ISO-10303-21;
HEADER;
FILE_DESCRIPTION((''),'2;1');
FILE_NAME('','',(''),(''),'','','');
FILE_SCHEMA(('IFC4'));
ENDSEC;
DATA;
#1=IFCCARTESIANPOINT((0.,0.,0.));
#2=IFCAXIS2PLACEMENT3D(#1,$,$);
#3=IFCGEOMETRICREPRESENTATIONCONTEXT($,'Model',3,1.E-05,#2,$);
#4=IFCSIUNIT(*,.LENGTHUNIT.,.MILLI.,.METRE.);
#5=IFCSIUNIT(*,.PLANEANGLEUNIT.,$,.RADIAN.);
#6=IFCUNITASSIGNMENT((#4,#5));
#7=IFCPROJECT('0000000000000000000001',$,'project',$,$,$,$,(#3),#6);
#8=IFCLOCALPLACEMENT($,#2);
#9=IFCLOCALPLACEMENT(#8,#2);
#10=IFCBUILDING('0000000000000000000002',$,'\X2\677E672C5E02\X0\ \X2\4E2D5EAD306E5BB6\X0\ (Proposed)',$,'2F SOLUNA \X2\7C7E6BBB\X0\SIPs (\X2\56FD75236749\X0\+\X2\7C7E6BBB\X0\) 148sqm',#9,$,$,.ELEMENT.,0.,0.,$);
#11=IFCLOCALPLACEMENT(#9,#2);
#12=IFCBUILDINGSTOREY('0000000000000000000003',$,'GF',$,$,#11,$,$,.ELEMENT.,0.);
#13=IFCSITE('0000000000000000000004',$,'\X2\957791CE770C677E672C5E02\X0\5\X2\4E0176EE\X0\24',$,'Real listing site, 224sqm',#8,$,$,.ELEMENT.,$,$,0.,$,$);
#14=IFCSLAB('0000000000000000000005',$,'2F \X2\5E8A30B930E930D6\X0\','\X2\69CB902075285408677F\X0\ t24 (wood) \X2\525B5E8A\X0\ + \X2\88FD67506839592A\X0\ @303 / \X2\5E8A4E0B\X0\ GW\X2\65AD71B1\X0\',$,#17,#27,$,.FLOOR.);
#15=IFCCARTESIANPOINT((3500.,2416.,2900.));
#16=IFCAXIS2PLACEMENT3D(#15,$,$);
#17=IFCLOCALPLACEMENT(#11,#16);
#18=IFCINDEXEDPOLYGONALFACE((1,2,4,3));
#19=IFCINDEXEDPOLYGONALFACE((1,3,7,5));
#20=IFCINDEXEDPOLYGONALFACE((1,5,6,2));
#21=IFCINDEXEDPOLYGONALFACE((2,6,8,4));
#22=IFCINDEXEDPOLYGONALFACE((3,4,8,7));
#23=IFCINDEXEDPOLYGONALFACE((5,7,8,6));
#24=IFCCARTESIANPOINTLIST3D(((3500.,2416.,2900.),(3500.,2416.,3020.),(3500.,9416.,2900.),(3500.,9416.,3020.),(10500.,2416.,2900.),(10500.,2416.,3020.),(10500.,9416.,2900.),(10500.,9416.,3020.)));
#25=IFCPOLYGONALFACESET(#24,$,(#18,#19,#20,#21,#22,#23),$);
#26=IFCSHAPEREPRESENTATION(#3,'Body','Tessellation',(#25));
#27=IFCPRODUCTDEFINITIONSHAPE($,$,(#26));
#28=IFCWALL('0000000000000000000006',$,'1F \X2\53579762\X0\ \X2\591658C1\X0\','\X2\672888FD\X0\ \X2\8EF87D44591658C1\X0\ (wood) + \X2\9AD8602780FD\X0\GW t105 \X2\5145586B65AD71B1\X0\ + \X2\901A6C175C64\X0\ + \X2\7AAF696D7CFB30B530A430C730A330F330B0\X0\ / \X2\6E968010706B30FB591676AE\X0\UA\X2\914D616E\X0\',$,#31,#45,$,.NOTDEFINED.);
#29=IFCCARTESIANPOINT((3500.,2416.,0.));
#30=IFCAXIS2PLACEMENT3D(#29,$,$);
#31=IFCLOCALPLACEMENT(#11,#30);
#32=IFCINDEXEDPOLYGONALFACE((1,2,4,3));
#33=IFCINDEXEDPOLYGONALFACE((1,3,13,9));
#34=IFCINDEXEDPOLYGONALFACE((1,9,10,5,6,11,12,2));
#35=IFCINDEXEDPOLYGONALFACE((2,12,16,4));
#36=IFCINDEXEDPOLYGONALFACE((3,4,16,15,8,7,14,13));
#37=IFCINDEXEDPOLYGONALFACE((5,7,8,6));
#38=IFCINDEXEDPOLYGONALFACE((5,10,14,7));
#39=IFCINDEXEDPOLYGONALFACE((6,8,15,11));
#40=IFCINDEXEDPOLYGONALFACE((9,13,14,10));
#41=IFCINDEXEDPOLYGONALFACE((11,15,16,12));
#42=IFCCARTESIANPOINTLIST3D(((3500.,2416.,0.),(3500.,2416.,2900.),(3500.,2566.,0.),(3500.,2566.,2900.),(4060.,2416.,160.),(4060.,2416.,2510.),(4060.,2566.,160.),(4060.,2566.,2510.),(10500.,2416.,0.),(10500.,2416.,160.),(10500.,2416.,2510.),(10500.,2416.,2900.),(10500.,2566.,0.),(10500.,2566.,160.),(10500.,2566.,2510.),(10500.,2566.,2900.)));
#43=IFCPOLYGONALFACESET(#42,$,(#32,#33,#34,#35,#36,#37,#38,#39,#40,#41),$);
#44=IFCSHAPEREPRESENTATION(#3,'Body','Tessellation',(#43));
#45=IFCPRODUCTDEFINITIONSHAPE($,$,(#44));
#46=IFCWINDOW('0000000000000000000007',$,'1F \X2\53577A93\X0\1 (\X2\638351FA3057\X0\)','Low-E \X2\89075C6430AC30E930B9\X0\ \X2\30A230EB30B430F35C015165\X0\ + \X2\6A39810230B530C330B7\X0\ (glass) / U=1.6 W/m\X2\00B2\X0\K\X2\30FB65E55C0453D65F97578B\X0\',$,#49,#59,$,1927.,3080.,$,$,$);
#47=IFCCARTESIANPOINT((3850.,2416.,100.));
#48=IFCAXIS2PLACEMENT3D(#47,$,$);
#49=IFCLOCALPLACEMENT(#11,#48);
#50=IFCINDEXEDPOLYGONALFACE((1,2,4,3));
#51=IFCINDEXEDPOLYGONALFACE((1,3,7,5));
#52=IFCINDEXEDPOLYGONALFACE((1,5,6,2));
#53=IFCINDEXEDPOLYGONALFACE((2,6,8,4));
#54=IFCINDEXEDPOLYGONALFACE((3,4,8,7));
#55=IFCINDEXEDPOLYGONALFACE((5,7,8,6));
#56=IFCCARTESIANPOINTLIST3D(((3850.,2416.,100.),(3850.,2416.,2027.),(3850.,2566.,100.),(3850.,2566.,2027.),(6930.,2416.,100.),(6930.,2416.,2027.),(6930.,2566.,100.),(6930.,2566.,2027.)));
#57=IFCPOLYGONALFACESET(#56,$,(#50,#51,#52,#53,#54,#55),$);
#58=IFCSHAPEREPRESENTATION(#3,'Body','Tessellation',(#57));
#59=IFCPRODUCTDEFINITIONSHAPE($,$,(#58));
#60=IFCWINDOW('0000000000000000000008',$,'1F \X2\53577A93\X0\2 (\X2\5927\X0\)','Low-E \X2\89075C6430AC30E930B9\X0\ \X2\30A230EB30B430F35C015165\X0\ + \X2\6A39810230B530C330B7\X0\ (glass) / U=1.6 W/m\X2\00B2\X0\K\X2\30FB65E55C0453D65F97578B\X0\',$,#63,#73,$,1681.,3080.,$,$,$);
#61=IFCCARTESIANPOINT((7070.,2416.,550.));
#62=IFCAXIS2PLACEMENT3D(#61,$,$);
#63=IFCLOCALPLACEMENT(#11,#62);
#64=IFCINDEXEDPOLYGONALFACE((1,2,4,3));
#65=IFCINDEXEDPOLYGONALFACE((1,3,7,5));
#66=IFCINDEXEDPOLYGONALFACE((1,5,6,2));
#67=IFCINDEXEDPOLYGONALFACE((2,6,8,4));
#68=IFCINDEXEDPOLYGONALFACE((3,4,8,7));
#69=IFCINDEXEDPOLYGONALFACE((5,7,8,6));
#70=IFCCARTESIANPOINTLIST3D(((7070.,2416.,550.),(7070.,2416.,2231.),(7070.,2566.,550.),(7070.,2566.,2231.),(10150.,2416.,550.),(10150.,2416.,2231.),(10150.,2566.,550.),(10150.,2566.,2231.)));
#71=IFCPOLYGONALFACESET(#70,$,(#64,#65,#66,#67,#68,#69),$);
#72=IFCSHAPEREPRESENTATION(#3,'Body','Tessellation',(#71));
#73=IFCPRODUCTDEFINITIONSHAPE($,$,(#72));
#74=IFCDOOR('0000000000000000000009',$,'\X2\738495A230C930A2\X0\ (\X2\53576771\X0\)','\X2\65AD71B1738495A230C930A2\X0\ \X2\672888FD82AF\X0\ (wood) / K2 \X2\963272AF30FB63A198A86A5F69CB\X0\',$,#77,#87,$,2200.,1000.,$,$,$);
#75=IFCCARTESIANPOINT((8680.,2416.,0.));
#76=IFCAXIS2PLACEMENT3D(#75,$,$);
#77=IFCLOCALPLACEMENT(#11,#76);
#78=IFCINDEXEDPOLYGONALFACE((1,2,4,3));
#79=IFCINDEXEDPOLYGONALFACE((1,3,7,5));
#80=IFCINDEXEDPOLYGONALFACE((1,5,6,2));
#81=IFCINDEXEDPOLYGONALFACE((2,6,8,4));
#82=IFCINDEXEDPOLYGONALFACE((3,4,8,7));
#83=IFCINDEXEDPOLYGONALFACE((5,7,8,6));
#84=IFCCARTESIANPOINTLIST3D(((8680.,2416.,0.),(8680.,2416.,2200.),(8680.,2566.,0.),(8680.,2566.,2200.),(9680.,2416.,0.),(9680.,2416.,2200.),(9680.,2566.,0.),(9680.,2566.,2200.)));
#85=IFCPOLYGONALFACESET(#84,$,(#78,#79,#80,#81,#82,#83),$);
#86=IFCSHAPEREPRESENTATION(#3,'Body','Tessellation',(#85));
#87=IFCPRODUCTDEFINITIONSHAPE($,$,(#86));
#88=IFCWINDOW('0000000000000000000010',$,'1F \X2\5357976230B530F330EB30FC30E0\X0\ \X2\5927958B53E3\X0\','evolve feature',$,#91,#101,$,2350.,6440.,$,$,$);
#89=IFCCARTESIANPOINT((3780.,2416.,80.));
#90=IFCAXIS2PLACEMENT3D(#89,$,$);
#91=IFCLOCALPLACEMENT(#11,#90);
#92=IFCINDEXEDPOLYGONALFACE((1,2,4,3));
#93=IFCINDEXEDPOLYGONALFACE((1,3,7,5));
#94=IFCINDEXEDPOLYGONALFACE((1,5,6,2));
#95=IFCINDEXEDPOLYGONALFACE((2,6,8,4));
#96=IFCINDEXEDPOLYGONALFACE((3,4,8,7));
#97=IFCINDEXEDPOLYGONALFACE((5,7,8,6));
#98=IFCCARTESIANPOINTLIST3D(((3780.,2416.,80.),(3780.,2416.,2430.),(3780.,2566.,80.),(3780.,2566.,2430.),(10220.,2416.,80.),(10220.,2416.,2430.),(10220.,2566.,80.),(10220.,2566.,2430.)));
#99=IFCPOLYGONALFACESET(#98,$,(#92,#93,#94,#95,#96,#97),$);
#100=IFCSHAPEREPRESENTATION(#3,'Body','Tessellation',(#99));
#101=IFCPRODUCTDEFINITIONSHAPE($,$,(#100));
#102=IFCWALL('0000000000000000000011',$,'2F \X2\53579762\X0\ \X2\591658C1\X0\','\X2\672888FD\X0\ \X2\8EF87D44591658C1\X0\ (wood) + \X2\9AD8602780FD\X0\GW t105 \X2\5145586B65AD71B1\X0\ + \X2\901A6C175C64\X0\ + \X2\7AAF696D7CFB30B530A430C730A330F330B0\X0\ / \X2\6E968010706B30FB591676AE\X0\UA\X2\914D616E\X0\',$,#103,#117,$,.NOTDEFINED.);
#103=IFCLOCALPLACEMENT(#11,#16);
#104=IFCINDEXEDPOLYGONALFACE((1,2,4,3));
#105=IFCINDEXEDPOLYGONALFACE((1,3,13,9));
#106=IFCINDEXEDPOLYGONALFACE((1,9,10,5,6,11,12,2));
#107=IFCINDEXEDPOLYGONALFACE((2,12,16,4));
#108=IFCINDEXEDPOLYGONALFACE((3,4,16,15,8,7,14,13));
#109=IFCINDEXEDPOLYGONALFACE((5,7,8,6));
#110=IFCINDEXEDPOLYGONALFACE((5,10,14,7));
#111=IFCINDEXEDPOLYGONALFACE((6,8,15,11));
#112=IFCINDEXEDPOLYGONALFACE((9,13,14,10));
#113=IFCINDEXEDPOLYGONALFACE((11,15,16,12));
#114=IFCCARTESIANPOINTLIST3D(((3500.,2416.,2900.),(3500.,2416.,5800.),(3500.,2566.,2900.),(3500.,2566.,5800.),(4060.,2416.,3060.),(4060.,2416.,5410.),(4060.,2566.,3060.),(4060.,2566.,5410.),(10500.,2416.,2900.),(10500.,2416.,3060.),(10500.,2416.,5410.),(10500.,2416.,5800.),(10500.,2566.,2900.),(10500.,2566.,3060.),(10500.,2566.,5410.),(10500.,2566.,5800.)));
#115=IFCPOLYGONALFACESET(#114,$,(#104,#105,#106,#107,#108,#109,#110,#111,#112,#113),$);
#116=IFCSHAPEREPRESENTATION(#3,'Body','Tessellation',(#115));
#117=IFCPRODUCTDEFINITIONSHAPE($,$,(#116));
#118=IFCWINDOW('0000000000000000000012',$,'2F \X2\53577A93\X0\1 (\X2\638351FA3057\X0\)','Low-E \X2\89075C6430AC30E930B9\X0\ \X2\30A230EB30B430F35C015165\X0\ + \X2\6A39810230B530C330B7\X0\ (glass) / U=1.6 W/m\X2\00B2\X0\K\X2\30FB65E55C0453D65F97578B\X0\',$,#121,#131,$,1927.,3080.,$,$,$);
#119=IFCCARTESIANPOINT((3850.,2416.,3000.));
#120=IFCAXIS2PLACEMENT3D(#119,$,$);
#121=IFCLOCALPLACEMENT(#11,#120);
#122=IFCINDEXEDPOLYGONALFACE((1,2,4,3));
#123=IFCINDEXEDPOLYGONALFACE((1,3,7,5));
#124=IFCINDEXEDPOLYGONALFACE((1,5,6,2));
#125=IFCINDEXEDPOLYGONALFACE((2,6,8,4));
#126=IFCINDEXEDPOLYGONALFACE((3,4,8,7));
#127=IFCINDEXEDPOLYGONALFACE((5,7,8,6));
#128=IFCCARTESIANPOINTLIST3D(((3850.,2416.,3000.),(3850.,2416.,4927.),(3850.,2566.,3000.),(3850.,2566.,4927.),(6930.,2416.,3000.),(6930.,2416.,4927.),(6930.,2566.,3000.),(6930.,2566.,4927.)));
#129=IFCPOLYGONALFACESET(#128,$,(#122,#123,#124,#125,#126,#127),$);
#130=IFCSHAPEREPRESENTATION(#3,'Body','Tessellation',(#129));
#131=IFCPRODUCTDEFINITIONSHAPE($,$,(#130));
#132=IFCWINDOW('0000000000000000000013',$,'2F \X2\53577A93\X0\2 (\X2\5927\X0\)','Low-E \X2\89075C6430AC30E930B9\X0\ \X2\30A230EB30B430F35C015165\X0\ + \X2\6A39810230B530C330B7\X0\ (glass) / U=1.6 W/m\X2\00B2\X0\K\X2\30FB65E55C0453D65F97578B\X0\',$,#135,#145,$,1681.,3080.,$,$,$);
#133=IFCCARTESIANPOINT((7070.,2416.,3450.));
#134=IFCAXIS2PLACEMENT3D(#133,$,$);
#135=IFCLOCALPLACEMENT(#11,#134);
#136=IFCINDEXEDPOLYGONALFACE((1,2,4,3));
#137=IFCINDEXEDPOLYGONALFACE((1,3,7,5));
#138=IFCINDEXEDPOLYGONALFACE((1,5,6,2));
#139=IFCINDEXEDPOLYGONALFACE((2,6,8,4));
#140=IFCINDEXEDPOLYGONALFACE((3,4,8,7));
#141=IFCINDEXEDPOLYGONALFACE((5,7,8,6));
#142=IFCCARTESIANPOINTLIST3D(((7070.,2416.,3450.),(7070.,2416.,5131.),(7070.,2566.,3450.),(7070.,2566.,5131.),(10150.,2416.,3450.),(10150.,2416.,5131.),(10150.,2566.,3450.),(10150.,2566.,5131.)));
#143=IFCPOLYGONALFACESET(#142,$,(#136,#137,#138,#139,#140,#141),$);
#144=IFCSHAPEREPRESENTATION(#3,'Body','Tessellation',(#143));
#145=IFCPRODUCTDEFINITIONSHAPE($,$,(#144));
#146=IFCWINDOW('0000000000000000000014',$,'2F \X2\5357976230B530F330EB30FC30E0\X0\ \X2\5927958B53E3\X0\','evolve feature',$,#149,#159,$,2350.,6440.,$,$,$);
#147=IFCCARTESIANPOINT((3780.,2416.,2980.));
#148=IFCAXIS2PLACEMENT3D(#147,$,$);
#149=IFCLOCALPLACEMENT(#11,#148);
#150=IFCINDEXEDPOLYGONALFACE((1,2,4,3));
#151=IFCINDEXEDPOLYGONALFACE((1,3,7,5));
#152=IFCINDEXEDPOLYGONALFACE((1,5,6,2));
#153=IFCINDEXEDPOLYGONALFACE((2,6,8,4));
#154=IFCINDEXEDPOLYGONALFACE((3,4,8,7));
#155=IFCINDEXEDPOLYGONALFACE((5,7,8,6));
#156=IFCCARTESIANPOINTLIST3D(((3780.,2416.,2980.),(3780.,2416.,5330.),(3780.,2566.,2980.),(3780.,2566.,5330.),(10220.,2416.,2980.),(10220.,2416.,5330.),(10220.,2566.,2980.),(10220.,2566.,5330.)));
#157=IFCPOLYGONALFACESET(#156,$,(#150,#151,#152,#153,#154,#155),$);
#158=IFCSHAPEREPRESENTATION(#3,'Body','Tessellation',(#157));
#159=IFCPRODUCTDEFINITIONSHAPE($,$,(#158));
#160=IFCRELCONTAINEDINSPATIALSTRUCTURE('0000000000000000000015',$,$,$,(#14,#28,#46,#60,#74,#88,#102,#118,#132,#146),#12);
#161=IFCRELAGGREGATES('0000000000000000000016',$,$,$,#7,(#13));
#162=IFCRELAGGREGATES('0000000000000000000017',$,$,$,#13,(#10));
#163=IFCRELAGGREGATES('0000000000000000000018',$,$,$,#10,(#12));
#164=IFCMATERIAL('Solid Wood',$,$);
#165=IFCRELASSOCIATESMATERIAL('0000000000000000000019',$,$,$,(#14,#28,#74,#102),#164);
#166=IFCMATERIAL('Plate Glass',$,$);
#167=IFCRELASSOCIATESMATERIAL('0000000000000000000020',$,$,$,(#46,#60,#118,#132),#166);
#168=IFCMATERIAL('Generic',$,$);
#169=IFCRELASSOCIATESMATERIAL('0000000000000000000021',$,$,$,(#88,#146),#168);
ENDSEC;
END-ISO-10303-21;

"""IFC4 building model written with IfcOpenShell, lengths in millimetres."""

from ifc_helpers import new_model, si_unit, frame, frame_2d, origin, place, context, project, spatial, rectangle, extrude, material, element, fill, save


model = new_model("IFC4")

# Units and contexts
model_context = context("Model", 3, precision=1e-05, world=origin())
ifc_project = project(units=[si_unit("LENGTHUNIT", "METRE", prefix="MILLI"), si_unit("PLANEANGLEUNIT", "RADIAN")], contexts=[model_context])

# Site, building, storey
site_placement = place(None, origin())
site = spatial("IfcSite", under=ifc_project, at=site_placement, Name="長野県松本市5丁目24", ObjectType="Real listing site, 224sqm", CompositionType="ELEMENT", RefElevation=0.0)
building_placement = place(site_placement, origin())
building = spatial("IfcBuilding", under=site, at=building_placement, Name="松本市 中庭の家 (Proposed)", ObjectType="2F SOLUNA 籾殻SIPs (国産杉+籾殻) 148sqm", CompositionType="ELEMENT", ElevationOfRefHeight=0.0, ElevationOfTerrain=0.0)
storey_placement = place(building_placement, origin())
storey = spatial("IfcBuildingStorey", under=building, at=storey_placement, Name="GF", CompositionType="ELEMENT", Elevation=0.0)

# Slab
ifc_material_1 = material(Name="Solid Wood")
slab_1_placement = place(storey_placement, frame((3500.0, 2416.0, 2900.0)))
element("IfcSlab", 1, at=slab_1_placement, inside=storey, material=ifc_material_1, Name="2F 床スラブ", Description="構造用合板 t24 (wood) 剛床 + 製材根太 @303 / 床下 GW断熱", PredefinedType="FLOOR", context=model_context, shape_type="SweptSolid", body=[
    extrude(rectangle(XDim=7000.0, YDim=7000.0, at=frame_2d((3500.0, 3500.0))), frame((3500.0, 2416.0, 2900.0)), (0.0, 0.0, 1.0), 120.0),
])
ifc_material_2 = material(Name="Generic")

# Wall, openings, windows, door
wall_1_placement = place(storey_placement, frame((3500.0, 2416.0, 0.0)))
wall_1 = element("IfcWall", 2, at=wall_1_placement, inside=storey, material=ifc_material_1, Name="1F 南面 外壁", Description="木製 軸組外壁 (wood) + 高性能GW t105 充填断熱 + 通気層 + 窯業系サイディング / 準耐火・外皮UA配慮", PredefinedType="NOTDEFINED", context=model_context, shape_type="SweptSolid", body=[
    extrude(rectangle(XDim=7000.0, YDim=150.0, at=frame_2d((3500.0, 75.0))), frame((3500.0, 2416.0, 0.0)), (0.0, 0.0, 1.0), 2900.0),
])
opening_1_placement = place(storey_placement, frame((3850.0, 2416.0, 100.0)))
opening_1 = element("IfcOpeningElement", 3, at=opening_1_placement, cuts=wall_1, PredefinedType="NOTDEFINED", context=model_context, shape_type="SweptSolid", body=[
    extrude(rectangle(XDim=3080.0, YDim=150.0, at=frame_2d((1540.0, 75.0))), frame((3850.0, 2416.0, 100.0)), (0.0, 0.0, 1.0), 1927.0),
])
opening_2_placement = place(storey_placement, frame((7070.0, 2416.0, 550.0)))
opening_2 = element("IfcOpeningElement", 4, at=opening_2_placement, cuts=wall_1, PredefinedType="NOTDEFINED", context=model_context, shape_type="SweptSolid", body=[
    extrude(rectangle(XDim=3080.0, YDim=150.0, at=frame_2d((1540.0, 75.0))), frame((7070.0, 2416.0, 550.0)), (0.0, 0.0, 1.0), 1681.0),
])
opening_3_placement = place(storey_placement, frame((8680.0, 2416.0, 0.0)))
opening_3 = element("IfcOpeningElement", 5, at=opening_3_placement, cuts=wall_1, PredefinedType="NOTDEFINED", context=model_context, shape_type="SweptSolid", body=[
    extrude(rectangle(XDim=1000.0, YDim=150.0, at=frame_2d((500.0, 75.0))), frame((8680.0, 2416.0, 0.0)), (0.0, 0.0, 1.0), 2200.0),
])
opening_4_placement = place(storey_placement, frame((3780.0, 2416.0, 80.0)))
opening_4 = element("IfcOpeningElement", 6, at=opening_4_placement, cuts=wall_1, PredefinedType="NOTDEFINED", context=model_context, shape_type="SweptSolid", body=[
    extrude(rectangle(XDim=6440.0, YDim=150.0, at=frame_2d((3220.0, 75.0))), frame((3780.0, 2416.0, 80.0)), (0.0, 0.0, 1.0), 2350.0),
])
ifc_material_3 = material(Name="Plate Glass")
window_1_placement = place(storey_placement, frame((3850.0, 2416.0, 100.0)))
window_1 = element("IfcWindow", 7, at=window_1_placement, inside=storey, material=ifc_material_3, Name="1F 南窓1 (掃出し)", Description="Low-E 複層ガラス アルゴン封入 + 樹脂サッシ (glass) / U=1.6 W/m²K・日射取得型", OverallHeight=1927.0, OverallWidth=3080.0, context=model_context, shape_type="SweptSolid", body=[
    extrude(rectangle(XDim=3080.0, YDim=150.0, at=frame_2d((1540.0, 75.0))), frame((3850.0, 2416.0, 100.0)), (0.0, 0.0, 1.0), 1927.0),
])
fill(opening_1, window_1)
window_2_placement = place(storey_placement, frame((7070.0, 2416.0, 550.0)))
window_2 = element("IfcWindow", 8, at=window_2_placement, inside=storey, material=ifc_material_3, Name="1F 南窓2 (大)", Description="Low-E 複層ガラス アルゴン封入 + 樹脂サッシ (glass) / U=1.6 W/m²K・日射取得型", OverallHeight=1681.0, OverallWidth=3080.0, context=model_context, shape_type="SweptSolid", body=[
    extrude(rectangle(XDim=3080.0, YDim=150.0, at=frame_2d((1540.0, 75.0))), frame((7070.0, 2416.0, 550.0)), (0.0, 0.0, 1.0), 1681.0),
])
fill(opening_2, window_2)
door_placement = place(storey_placement, frame((8680.0, 2416.0, 0.0)))
door = element("IfcDoor", 9, at=door_placement, inside=storey, material=ifc_material_1, Name="玄関ドア (南東)", Description="断熱玄関ドア 木製芯 (wood) / K2 防犯・採風機構", OverallHeight=2200.0, OverallWidth=1000.0, context=model_context, shape_type="SweptSolid", body=[
    extrude(rectangle(XDim=1000.0, YDim=150.0, at=frame_2d((500.0, 75.0))), frame((8680.0, 2416.0, 0.0)), (0.0, 0.0, 1.0), 2200.0),
])
fill(opening_3, door)
window_3_placement = place(storey_placement, frame((3780.0, 2416.0, 80.0)))
window_3 = element("IfcWindow", 10, at=window_3_placement, inside=storey, material=ifc_material_2, Name="1F 南面サンルーム 大開口", Description="evolve feature", OverallHeight=2350.0, OverallWidth=6440.0, context=model_context, shape_type="SweptSolid", body=[
    extrude(rectangle(XDim=6440.0, YDim=150.0, at=frame_2d((3220.0, 75.0))), frame((3780.0, 2416.0, 80.0)), (0.0, 0.0, 1.0), 2350.0),
])
fill(opening_4, window_3)

# Wall, openings, windows
wall_2_placement = place(storey_placement, frame((3500.0, 2416.0, 2900.0)))
wall_2 = element("IfcWall", 11, at=wall_2_placement, inside=storey, material=ifc_material_1, Name="2F 南面 外壁", Description="木製 軸組外壁 (wood) + 高性能GW t105 充填断熱 + 通気層 + 窯業系サイディング / 準耐火・外皮UA配慮", PredefinedType="NOTDEFINED", context=model_context, shape_type="SweptSolid", body=[
    extrude(rectangle(XDim=7000.0, YDim=150.0, at=frame_2d((3500.0, 75.0))), frame((3500.0, 2416.0, 2900.0)), (0.0, 0.0, 1.0), 2900.0),
])
opening_5_placement = place(storey_placement, frame((3850.0, 2416.0, 3000.0)))
opening_5 = element("IfcOpeningElement", 12, at=opening_5_placement, cuts=wall_2, PredefinedType="NOTDEFINED", context=model_context, shape_type="SweptSolid", body=[
    extrude(rectangle(XDim=3080.0, YDim=150.0, at=frame_2d((1540.0, 75.0))), frame((3850.0, 2416.0, 3000.0)), (0.0, 0.0, 1.0), 1927.0),
])
opening_6_placement = place(storey_placement, frame((7070.0, 2416.0, 3450.0)))
opening_6 = element("IfcOpeningElement", 13, at=opening_6_placement, cuts=wall_2, PredefinedType="NOTDEFINED", context=model_context, shape_type="SweptSolid", body=[
    extrude(rectangle(XDim=3080.0, YDim=150.0, at=frame_2d((1540.0, 75.0))), frame((7070.0, 2416.0, 3450.0)), (0.0, 0.0, 1.0), 1681.0),
])
opening_7_placement = place(storey_placement, frame((3780.0, 2416.0, 2980.0)))
opening_7 = element("IfcOpeningElement", 14, at=opening_7_placement, cuts=wall_2, PredefinedType="NOTDEFINED", context=model_context, shape_type="SweptSolid", body=[
    extrude(rectangle(XDim=6440.0, YDim=150.0, at=frame_2d((3220.0, 75.0))), frame((3780.0, 2416.0, 2980.0)), (0.0, 0.0, 1.0), 2350.0),
])
window_4_placement = place(storey_placement, frame((3850.0, 2416.0, 3000.0)))
window_4 = element("IfcWindow", 15, at=window_4_placement, inside=storey, material=ifc_material_3, Name="2F 南窓1 (掃出し)", Description="Low-E 複層ガラス アルゴン封入 + 樹脂サッシ (glass) / U=1.6 W/m²K・日射取得型", OverallHeight=1927.0, OverallWidth=3080.0, context=model_context, shape_type="SweptSolid", body=[
    extrude(rectangle(XDim=3080.0, YDim=150.0, at=frame_2d((1540.0, 75.0))), frame((3850.0, 2416.0, 3000.0)), (0.0, 0.0, 1.0), 1927.0),
])
fill(opening_5, window_4)
window_5_placement = place(storey_placement, frame((7070.0, 2416.0, 3450.0)))
window_5 = element("IfcWindow", 16, at=window_5_placement, inside=storey, material=ifc_material_3, Name="2F 南窓2 (大)", Description="Low-E 複層ガラス アルゴン封入 + 樹脂サッシ (glass) / U=1.6 W/m²K・日射取得型", OverallHeight=1681.0, OverallWidth=3080.0, context=model_context, shape_type="SweptSolid", body=[
    extrude(rectangle(XDim=3080.0, YDim=150.0, at=frame_2d((1540.0, 75.0))), frame((7070.0, 2416.0, 3450.0)), (0.0, 0.0, 1.0), 1681.0),
])
fill(opening_6, window_5)
window_6_placement = place(storey_placement, frame((3780.0, 2416.0, 2980.0)))
window_6 = element("IfcWindow", 17, at=window_6_placement, inside=storey, material=ifc_material_2, Name="2F 南面サンルーム 大開口", Description="evolve feature", OverallHeight=2350.0, OverallWidth=6440.0, context=model_context, shape_type="SweptSolid", body=[
    extrude(rectangle(XDim=6440.0, YDim=150.0, at=frame_2d((3220.0, 75.0))), frame((3780.0, 2416.0, 2980.0)), (0.0, 0.0, 1.0), 2350.0),
])
fill(opening_7, window_6)

save(model, "model.ifc")
